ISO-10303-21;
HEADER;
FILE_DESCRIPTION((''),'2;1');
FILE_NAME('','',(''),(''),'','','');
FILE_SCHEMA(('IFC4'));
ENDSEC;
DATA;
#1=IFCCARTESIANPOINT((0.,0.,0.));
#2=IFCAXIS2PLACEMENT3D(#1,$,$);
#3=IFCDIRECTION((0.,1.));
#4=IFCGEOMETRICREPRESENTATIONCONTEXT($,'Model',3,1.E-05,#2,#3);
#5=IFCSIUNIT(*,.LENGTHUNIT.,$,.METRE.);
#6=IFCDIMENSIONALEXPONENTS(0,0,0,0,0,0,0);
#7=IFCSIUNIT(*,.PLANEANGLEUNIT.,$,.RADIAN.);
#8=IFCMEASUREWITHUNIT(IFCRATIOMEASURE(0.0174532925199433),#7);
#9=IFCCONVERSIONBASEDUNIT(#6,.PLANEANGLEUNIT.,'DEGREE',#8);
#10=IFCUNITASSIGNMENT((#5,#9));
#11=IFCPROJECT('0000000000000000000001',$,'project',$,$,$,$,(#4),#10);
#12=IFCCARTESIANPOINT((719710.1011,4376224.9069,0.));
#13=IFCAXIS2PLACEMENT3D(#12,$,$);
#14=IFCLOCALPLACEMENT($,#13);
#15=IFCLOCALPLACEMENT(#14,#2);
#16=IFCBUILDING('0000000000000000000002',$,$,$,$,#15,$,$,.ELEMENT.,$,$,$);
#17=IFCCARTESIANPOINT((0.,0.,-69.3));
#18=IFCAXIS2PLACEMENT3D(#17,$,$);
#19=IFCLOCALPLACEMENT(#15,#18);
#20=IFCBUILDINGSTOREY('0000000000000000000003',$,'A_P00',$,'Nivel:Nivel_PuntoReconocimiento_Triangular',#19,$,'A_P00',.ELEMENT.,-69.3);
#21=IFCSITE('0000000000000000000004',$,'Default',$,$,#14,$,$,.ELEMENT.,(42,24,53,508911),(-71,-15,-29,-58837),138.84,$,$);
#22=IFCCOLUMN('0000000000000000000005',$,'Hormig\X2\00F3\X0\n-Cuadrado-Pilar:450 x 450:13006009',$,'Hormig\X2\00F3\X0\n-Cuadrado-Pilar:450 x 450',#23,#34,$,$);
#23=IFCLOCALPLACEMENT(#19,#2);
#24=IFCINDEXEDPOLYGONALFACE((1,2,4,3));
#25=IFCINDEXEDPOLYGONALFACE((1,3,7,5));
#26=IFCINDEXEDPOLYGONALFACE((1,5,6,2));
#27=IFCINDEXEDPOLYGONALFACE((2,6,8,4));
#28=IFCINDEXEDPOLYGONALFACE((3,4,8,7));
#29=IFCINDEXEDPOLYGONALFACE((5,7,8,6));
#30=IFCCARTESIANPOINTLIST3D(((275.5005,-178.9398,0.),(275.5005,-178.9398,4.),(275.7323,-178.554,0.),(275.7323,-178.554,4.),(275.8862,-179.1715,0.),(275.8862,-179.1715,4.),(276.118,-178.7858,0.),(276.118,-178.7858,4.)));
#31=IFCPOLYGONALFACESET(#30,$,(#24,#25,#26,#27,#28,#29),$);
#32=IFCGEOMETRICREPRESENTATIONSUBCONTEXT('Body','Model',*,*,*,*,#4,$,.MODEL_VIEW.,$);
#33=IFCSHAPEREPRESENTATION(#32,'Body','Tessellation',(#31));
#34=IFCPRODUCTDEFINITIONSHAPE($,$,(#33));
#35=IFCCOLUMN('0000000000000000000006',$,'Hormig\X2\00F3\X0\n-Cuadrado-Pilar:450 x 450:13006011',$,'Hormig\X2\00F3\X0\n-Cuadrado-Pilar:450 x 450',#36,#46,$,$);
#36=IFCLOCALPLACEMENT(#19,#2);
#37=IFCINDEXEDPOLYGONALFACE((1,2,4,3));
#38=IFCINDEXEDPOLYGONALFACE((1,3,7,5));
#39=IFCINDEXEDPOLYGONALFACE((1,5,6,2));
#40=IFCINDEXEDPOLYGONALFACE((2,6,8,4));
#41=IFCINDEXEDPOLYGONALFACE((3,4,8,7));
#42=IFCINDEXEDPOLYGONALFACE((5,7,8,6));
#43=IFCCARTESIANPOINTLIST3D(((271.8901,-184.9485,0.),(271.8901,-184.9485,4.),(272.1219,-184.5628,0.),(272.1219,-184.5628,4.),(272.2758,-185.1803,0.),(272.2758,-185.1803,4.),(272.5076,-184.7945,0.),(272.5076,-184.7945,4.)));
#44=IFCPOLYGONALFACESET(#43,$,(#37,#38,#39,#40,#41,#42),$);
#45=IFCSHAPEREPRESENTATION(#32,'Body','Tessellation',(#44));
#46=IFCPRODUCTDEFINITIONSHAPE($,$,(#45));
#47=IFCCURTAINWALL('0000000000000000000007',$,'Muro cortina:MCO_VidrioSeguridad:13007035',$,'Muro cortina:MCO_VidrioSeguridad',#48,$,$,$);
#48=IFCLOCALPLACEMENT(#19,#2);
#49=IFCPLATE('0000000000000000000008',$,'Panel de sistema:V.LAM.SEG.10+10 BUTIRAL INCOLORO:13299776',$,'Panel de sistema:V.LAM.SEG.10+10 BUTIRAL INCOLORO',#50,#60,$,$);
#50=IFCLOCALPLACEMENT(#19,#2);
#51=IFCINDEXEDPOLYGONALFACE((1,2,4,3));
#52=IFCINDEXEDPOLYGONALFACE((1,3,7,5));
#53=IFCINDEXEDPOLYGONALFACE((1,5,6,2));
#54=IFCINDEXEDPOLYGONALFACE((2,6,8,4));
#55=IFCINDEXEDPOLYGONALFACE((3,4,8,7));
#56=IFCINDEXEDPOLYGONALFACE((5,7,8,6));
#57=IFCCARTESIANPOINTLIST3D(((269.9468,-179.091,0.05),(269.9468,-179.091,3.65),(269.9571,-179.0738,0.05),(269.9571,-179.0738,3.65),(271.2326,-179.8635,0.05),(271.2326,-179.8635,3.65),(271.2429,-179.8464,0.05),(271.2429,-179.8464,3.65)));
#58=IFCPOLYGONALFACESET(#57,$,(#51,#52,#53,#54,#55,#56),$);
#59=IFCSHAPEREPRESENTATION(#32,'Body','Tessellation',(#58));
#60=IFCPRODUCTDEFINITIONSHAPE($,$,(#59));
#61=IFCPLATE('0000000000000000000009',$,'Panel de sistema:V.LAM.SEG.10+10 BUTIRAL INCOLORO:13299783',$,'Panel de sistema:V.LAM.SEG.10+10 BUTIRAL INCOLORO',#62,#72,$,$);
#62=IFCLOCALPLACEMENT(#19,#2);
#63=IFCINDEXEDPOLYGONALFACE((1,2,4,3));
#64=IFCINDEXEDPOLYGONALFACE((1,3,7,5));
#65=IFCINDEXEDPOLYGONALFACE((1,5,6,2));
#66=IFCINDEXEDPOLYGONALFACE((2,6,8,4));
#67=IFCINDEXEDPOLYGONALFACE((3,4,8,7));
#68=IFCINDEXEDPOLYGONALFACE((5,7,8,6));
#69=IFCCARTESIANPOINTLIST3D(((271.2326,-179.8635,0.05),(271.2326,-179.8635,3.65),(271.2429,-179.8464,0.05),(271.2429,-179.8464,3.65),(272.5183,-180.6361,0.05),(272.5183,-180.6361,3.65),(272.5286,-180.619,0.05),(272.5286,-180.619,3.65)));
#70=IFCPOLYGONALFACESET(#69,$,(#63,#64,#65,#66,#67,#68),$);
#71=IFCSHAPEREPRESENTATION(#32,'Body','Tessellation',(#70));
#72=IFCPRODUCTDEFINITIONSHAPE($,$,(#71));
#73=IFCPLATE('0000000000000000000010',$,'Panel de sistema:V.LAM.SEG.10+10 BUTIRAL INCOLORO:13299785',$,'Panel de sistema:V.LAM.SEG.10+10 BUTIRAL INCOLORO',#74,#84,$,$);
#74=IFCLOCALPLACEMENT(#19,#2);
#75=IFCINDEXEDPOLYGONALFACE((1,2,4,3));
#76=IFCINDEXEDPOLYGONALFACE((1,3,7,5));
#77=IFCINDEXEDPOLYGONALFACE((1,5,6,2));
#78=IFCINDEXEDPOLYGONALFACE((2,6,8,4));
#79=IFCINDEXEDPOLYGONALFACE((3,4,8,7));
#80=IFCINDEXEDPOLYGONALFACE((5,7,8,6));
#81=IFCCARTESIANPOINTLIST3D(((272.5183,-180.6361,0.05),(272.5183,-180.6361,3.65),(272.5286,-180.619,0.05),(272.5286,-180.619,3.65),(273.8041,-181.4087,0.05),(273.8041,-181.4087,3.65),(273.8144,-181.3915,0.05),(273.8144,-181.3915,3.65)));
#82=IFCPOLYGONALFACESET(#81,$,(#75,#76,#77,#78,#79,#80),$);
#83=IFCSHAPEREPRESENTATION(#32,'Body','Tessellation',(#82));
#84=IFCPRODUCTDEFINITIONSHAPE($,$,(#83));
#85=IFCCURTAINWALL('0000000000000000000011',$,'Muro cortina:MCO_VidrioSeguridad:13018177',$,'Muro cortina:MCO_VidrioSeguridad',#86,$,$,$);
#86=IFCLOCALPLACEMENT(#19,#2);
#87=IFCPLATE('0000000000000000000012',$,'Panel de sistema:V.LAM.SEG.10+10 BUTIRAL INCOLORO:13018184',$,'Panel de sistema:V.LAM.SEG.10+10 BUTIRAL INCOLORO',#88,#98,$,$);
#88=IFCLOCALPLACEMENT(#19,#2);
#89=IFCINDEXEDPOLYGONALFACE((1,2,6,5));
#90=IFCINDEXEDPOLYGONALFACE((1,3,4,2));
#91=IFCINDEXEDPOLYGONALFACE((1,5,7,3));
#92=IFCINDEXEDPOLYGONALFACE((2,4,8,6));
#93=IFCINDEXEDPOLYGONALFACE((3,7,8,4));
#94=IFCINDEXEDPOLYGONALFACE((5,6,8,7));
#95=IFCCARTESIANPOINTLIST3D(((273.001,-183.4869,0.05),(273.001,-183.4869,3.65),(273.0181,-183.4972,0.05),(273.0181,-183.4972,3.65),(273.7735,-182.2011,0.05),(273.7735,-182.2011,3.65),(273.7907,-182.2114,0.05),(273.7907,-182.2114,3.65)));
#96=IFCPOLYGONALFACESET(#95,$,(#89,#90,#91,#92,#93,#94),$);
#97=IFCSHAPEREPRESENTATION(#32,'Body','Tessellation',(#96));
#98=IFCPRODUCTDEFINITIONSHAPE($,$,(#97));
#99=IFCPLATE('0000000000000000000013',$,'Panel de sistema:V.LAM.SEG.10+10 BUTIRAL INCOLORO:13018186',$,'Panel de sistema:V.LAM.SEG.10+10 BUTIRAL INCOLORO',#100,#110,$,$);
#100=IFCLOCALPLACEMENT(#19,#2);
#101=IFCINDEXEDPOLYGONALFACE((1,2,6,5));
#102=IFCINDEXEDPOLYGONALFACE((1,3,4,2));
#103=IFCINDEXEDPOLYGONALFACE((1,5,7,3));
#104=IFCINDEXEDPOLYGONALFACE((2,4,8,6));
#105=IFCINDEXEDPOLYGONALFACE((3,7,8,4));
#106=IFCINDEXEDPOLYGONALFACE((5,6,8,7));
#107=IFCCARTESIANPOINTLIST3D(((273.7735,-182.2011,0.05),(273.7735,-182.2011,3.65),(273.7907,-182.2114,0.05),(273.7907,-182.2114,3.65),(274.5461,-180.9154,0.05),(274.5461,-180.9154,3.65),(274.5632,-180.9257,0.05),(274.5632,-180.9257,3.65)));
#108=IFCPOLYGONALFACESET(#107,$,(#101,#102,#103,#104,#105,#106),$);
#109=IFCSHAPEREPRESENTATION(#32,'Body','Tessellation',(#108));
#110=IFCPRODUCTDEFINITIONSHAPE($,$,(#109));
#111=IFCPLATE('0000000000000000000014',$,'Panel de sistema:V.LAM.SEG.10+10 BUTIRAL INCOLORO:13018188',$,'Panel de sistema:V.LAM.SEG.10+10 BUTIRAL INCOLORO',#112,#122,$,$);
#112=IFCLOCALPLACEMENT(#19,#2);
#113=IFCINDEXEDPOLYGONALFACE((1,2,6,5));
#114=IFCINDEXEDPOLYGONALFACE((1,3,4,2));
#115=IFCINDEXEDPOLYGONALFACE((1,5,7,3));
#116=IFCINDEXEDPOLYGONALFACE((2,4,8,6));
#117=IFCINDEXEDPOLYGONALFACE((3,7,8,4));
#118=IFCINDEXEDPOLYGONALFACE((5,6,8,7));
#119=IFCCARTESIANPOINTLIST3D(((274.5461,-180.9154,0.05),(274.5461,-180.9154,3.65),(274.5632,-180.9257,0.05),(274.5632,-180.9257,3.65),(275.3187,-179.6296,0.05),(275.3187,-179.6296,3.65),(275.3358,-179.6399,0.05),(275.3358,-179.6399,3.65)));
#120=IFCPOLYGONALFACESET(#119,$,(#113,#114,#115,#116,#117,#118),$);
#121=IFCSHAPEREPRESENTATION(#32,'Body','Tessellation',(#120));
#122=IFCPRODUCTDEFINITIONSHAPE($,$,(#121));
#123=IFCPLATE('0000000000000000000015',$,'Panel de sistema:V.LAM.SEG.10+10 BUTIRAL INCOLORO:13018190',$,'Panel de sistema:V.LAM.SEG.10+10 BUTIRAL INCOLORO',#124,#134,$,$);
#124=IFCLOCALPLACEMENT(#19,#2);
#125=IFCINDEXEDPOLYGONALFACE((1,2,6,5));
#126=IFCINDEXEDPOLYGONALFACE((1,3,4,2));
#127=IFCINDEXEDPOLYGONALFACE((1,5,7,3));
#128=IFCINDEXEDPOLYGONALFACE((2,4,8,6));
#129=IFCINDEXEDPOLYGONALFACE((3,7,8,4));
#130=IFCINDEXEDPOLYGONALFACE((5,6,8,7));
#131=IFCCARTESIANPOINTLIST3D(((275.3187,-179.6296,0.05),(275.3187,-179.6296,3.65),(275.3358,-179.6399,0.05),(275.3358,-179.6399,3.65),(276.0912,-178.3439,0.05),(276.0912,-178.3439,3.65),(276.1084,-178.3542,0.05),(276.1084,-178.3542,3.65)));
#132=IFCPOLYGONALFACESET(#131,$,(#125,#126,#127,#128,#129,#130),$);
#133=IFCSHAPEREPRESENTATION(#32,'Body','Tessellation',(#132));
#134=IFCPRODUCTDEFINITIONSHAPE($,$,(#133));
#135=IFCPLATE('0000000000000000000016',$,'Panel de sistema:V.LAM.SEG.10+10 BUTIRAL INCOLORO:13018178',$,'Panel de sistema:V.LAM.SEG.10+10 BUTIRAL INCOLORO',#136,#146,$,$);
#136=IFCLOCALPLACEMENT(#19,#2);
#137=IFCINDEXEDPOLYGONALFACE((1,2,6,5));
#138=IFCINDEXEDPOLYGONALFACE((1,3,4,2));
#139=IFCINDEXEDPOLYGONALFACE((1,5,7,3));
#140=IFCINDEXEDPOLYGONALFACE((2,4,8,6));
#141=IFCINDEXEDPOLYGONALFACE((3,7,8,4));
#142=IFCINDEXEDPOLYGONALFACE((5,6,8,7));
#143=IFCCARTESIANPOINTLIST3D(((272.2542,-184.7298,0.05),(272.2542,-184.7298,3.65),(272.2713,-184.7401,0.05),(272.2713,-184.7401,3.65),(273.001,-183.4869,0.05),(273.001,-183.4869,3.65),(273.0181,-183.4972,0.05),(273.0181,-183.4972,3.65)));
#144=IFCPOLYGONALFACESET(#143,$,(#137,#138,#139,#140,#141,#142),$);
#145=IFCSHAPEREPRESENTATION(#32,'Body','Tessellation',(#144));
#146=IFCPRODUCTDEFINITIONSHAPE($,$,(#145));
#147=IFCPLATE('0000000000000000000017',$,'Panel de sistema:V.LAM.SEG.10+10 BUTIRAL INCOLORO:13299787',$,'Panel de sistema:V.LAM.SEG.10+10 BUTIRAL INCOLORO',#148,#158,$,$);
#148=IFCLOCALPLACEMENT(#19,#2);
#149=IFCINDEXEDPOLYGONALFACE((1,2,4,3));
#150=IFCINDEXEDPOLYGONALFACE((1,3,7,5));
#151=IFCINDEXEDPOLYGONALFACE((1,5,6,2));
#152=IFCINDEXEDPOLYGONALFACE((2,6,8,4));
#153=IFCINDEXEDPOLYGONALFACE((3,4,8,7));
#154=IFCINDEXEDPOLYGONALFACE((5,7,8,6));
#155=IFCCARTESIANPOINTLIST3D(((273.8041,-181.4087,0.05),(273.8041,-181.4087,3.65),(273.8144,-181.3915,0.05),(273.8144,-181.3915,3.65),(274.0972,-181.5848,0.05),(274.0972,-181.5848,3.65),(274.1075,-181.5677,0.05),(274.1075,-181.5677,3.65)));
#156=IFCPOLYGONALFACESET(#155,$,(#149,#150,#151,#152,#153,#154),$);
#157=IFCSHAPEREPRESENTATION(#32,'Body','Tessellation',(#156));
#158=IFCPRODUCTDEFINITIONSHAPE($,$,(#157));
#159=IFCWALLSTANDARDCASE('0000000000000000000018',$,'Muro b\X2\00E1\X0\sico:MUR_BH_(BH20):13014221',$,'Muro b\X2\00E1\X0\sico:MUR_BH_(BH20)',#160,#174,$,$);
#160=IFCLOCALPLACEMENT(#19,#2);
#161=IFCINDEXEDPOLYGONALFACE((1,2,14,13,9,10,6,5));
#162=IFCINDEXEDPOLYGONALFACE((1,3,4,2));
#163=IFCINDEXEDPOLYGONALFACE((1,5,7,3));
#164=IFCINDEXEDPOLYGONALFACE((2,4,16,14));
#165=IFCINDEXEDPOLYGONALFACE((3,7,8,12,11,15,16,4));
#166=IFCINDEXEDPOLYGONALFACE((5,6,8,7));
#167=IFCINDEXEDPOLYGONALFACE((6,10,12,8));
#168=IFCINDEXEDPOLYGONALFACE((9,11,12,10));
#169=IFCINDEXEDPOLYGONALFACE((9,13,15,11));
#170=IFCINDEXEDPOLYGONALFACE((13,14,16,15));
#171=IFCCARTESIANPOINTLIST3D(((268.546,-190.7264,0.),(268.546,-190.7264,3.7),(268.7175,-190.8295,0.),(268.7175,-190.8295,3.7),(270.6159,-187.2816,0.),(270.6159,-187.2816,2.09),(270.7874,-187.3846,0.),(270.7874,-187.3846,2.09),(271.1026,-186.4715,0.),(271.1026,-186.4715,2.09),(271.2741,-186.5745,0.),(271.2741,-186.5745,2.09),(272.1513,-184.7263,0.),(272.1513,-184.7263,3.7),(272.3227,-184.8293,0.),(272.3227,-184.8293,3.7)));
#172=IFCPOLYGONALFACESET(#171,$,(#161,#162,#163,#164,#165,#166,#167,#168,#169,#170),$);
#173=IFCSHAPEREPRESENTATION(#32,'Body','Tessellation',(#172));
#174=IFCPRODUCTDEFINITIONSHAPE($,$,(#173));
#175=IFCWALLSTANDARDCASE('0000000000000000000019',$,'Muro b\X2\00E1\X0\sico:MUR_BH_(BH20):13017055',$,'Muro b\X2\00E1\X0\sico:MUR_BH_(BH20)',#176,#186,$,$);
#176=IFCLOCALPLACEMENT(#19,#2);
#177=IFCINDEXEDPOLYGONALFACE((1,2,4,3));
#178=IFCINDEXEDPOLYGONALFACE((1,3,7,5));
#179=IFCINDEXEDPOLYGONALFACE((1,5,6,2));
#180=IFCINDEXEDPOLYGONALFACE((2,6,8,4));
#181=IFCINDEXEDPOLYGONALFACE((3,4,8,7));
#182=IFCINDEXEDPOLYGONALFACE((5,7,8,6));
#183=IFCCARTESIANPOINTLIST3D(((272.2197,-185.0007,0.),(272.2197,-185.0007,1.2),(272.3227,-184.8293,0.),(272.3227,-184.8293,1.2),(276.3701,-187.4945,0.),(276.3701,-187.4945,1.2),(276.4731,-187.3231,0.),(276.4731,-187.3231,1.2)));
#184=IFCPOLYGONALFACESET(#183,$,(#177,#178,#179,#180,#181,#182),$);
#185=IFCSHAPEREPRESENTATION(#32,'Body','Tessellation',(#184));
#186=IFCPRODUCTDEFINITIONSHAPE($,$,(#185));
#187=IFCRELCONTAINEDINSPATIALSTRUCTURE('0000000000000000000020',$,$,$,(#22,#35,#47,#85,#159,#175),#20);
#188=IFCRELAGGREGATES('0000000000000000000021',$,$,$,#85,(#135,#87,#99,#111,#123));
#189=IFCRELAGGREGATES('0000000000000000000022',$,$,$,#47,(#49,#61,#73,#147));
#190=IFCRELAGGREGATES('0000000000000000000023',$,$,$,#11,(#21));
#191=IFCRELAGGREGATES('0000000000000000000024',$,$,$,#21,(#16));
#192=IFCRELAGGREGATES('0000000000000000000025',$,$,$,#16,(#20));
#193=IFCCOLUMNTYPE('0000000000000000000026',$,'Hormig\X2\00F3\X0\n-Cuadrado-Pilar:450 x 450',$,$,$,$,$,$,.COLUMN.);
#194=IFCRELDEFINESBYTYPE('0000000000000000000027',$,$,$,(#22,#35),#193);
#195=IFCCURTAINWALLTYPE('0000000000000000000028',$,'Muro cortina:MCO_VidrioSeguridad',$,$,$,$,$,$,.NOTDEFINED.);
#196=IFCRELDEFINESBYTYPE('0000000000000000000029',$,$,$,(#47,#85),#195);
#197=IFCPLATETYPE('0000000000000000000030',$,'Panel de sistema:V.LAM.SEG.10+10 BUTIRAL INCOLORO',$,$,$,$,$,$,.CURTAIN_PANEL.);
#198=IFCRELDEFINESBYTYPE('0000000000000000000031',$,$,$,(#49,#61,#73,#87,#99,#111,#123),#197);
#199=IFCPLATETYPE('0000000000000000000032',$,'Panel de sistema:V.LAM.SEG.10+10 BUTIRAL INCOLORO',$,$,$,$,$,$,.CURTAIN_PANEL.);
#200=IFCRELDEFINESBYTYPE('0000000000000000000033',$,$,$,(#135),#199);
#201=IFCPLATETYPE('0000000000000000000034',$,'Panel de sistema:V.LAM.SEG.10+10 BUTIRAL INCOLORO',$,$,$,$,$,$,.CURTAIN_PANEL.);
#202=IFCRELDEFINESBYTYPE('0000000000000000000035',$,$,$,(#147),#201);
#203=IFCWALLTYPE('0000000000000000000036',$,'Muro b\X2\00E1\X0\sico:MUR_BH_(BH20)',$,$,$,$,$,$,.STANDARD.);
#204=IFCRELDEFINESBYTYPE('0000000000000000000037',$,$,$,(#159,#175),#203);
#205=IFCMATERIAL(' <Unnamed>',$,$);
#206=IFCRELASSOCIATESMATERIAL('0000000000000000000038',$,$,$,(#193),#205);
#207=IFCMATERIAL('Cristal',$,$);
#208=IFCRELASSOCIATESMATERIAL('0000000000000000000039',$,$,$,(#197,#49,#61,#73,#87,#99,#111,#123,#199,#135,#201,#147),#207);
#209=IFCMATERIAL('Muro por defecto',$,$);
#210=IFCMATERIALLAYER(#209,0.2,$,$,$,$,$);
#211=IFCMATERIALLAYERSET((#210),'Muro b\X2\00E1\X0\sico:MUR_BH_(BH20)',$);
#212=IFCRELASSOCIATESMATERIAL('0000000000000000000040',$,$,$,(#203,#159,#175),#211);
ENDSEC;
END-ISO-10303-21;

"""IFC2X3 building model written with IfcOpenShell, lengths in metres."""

from ifc_helpers import new_model, entity, si_unit, converted_unit, direction, frame, frame_2d, origin, origin_2d_with_axis, place, context, subcontext, project, spatial, rectangle, extrude, source, transform, mapped, material, layer, layer_set, layer_usage, type_object, type_shapes, element, aggregate, save


model = new_model("IFC2X3")

# Units and contexts
model_context = context("Model", 3, precision=1e-05, world=origin(), true_north=direction((0.0, 1.0)))
body_context = subcontext(model_context, "Body", "Model", "MODEL_VIEW")
ifc_project = project(units=[si_unit("LENGTHUNIT", "METRE"), converted_unit("PLANEANGLEUNIT", "DEGREE", entity("IfcRatioMeasure", 0.0174532925199433), si_unit("PLANEANGLEUNIT", "RADIAN"), dimensions=[0, 0, 0, 0, 0, 0, 0])], contexts=[model_context])

# Site, building, storey
site_placement = place(None, frame((719710.1011, 4376224.9069, 0.0)))
site = spatial("IfcSite", under=ifc_project, at=site_placement, Name="Default", CompositionType="ELEMENT", RefLatitude=(42, 24, 53, 508911), RefLongitude=(-71, -15, -29, -58837), RefElevation=138.84)
building_placement = place(site_placement, origin())
building = spatial("IfcBuilding", under=site, at=building_placement, CompositionType="ELEMENT")
storey_placement = place(building_placement, frame((0.0, 0.0, -69.3)))
storey = spatial("IfcBuildingStorey", under=building, at=storey_placement, Name="A_P00", ObjectType="Nivel:Nivel_PuntoReconocimiento_Triangular", LongName="A_P00", CompositionType="ELEMENT", Elevation=-69.3)

# Columns
ifc_material_1 = material(Name=" <Unnamed>")
column_type = type_object("IfcColumnType", Name="Hormigón-Cuadrado-Pilar:450 x 450", PredefinedType="COLUMN", material=ifc_material_1)
shared_shape_1 = source(origin(), body_context, "Body", "SweptSolid", [
    extrude(rectangle(XDim=0.45, YDim=0.45, at=origin_2d_with_axis()), frame((0.0, 0.0, -69.3), z_axis=(0.0, 0.0, 1.0), x_axis=(0.0, -1.0, 0.0)), (0.0, 0.0, 1.0), 4.0),
])
type_shapes(column_type, [shared_shape_1])
for number, where, z_axis, x_axis, name in (
    (1, (275.8093, -178.8628, 69.3), (0.0, 0.0, 1.0), (0.857167, -0.515038, 0.0), "Hormigón-Cuadrado-Pilar:450 x 450:13006009"),
    (2, (272.1988, -184.8715, 69.3), (0.0, 0.0, 1.0), (0.857167, -0.515038, 0.0), "Hormigón-Cuadrado-Pilar:450 x 450:13006011"),
):
    element("IfcColumn", number, at=place(storey_placement, frame(where, z_axis=z_axis, x_axis=x_axis)), inside=storey, type_object=column_type, Name=name, ObjectType="Hormigón-Cuadrado-Pilar:450 x 450", context=body_context, shape_type="MappedRepresentation", body=[
        mapped(shared_shape_1, transform((0.0, 0.0, 0.0), scale=1.0)),
    ])

# Curtain walls, plates
curtain_wall_type = type_object("IfcCurtainWallType", Name="Muro cortina:MCO_VidrioSeguridad", PredefinedType="NOTDEFINED")
curtain_wall_1_placement = place(storey_placement, frame((0.0, 0.0, 69.3)))
curtain_wall_1 = element("IfcCurtainWall", 3, at=curtain_wall_1_placement, inside=storey, type_object=curtain_wall_type, Name="Muro cortina:MCO_VidrioSeguridad:13007035", ObjectType="Muro cortina:MCO_VidrioSeguridad")
ifc_material_2 = material(Name="Cristal")
plate_type_1 = type_object("IfcPlateType", Name="Panel de sistema:V.LAM.SEG.10+10 BUTIRAL INCOLORO", PredefinedType="CURTAIN_PANEL", material=ifc_material_2)
shared_shape_2 = source(origin(), body_context, "Body", "SweptSolid", [
    extrude(rectangle(XDim=0.02, YDim=1.5, at=origin_2d_with_axis()), frame((0.0, 0.0, 0.0), z_axis=(0.0, 0.0, 1.0), x_axis=(0.0, 1.0, 0.0)), (0.0, 0.0, 1.0), 3.6),
])
type_shapes(plate_type_1, [shared_shape_2])
plate_1_placement = place(curtain_wall_1_placement, frame((270.5948, -179.4687, -69.25), z_axis=(0.0, 0.0, 1.0), x_axis=(0.857167, -0.515038, 0.0)))
plate_1 = element("IfcPlate", 4, at=plate_1_placement, type_object=plate_type_1, material=ifc_material_2, Name="Panel de sistema:V.LAM.SEG.10+10 BUTIRAL INCOLORO:13299776", ObjectType="Panel de sistema:V.LAM.SEG.10+10 BUTIRAL INCOLORO", context=body_context, shape_type="MappedRepresentation", body=[
    mapped(shared_shape_2, transform((0.0, 0.0, 0.0), scale=1.0)),
])
plate_2_placement = place(curtain_wall_1_placement, frame((271.8806, -180.2412, -69.25), z_axis=(0.0, 0.0, 1.0), x_axis=(0.857167, -0.515038, 0.0)))
plate_2 = element("IfcPlate", 5, at=plate_2_placement, type_object=plate_type_1, material=ifc_material_2, Name="Panel de sistema:V.LAM.SEG.10+10 BUTIRAL INCOLORO:13299783", ObjectType="Panel de sistema:V.LAM.SEG.10+10 BUTIRAL INCOLORO", context=body_context, shape_type="MappedRepresentation", body=[
    mapped(shared_shape_2, transform((0.0, 0.0, 0.0), scale=1.0)),
])
plate_3_placement = place(curtain_wall_1_placement, frame((273.1663, -181.0138, -69.25), z_axis=(0.0, 0.0, 1.0), x_axis=(0.857167, -0.515038, 0.0)))
plate_3 = element("IfcPlate", 6, at=plate_3_placement, type_object=plate_type_1, material=ifc_material_2, Name="Panel de sistema:V.LAM.SEG.10+10 BUTIRAL INCOLORO:13299785", ObjectType="Panel de sistema:V.LAM.SEG.10+10 BUTIRAL INCOLORO", context=body_context, shape_type="MappedRepresentation", body=[
    mapped(shared_shape_2, transform((0.0, 0.0, 0.0), scale=1.0)),
])
curtain_wall_2_placement = place(storey_placement, frame((0.0, 0.0, 69.3)))
curtain_wall_2 = element("IfcCurtainWall", 7, at=curtain_wall_2_placement, inside=storey, type_object=curtain_wall_type, Name="Muro cortina:MCO_VidrioSeguridad:13018177", ObjectType="Muro cortina:MCO_VidrioSeguridad")
plate_4_placement = place(curtain_wall_2_placement, frame((273.3958, -182.8492, -69.25), z_axis=(0.0, 0.0, 1.0), x_axis=(0.515038, 0.857167, 0.0)))
plate_4 = element("IfcPlate", 8, at=plate_4_placement, type_object=plate_type_1, material=ifc_material_2, Name="Panel de sistema:V.LAM.SEG.10+10 BUTIRAL INCOLORO:13018184", ObjectType="Panel de sistema:V.LAM.SEG.10+10 BUTIRAL INCOLORO", context=body_context, shape_type="MappedRepresentation", body=[
    mapped(shared_shape_2, transform((0.0, 0.0, 0.0), scale=1.0)),
])
plate_5_placement = place(curtain_wall_2_placement, frame((274.1684, -181.5634, -69.25), z_axis=(0.0, 0.0, 1.0), x_axis=(0.515038, 0.857167, 0.0)))
plate_5 = element("IfcPlate", 9, at=plate_5_placement, type_object=plate_type_1, material=ifc_material_2, Name="Panel de sistema:V.LAM.SEG.10+10 BUTIRAL INCOLORO:13018186", ObjectType="Panel de sistema:V.LAM.SEG.10+10 BUTIRAL INCOLORO", context=body_context, shape_type="MappedRepresentation", body=[
    mapped(shared_shape_2, transform((0.0, 0.0, 0.0), scale=1.0)),
])
plate_6_placement = place(curtain_wall_2_placement, frame((274.941, -180.2777, -69.25), z_axis=(0.0, 0.0, 1.0), x_axis=(0.515038, 0.857167, 0.0)))
plate_6 = element("IfcPlate", 10, at=plate_6_placement, type_object=plate_type_1, material=ifc_material_2, Name="Panel de sistema:V.LAM.SEG.10+10 BUTIRAL INCOLORO:13018188", ObjectType="Panel de sistema:V.LAM.SEG.10+10 BUTIRAL INCOLORO", context=body_context, shape_type="MappedRepresentation", body=[
    mapped(shared_shape_2, transform((0.0, 0.0, 0.0), scale=1.0)),
])
plate_7_placement = place(curtain_wall_2_placement, frame((275.7135, -178.9919, -69.25), z_axis=(0.0, 0.0, 1.0), x_axis=(0.515038, 0.857167, 0.0)))
plate_7 = element("IfcPlate", 11, at=plate_7_placement, type_object=plate_type_1, material=ifc_material_2, Name="Panel de sistema:V.LAM.SEG.10+10 BUTIRAL INCOLORO:13018190", ObjectType="Panel de sistema:V.LAM.SEG.10+10 BUTIRAL INCOLORO", context=body_context, shape_type="MappedRepresentation", body=[
    mapped(shared_shape_2, transform((0.0, 0.0, 0.0), scale=1.0)),
])
plate_type_2 = type_object("IfcPlateType", Name="Panel de sistema:V.LAM.SEG.10+10 BUTIRAL INCOLORO", PredefinedType="CURTAIN_PANEL", material=ifc_material_2)
shared_shape_3 = source(origin(), body_context, "Body", "SweptSolid", [
    extrude(rectangle(XDim=0.02, YDim=1.45, at=origin_2d_with_axis()), frame((0.0, 0.0, 0.0), z_axis=(0.0, 0.0, 1.0), x_axis=(0.0, 1.0, 0.0)), (0.0, 0.0, 1.0), 3.6),
])
type_shapes(plate_type_2, [shared_shape_3])
plate_8_placement = place(curtain_wall_2_placement, frame((272.6362, -184.1135, -69.25), z_axis=(0.0, 0.0, 1.0), x_axis=(0.515038, 0.857167, 0.0)))
plate_8 = element("IfcPlate", 12, at=plate_8_placement, type_object=plate_type_2, material=ifc_material_2, Name="Panel de sistema:V.LAM.SEG.10+10 BUTIRAL INCOLORO:13018178", ObjectType="Panel de sistema:V.LAM.SEG.10+10 BUTIRAL INCOLORO", context=body_context, shape_type="MappedRepresentation", body=[
    mapped(shared_shape_3, transform((0.0, 0.0, 0.0), scale=1.0)),
])
aggregate(curtain_wall_2, [plate_8, plate_4, plate_5, plate_6, plate_7])

# Plate
plate_type_3 = type_object("IfcPlateType", Name="Panel de sistema:V.LAM.SEG.10+10 BUTIRAL INCOLORO", PredefinedType="CURTAIN_PANEL", material=ifc_material_2)
shared_shape_4 = source(origin(), body_context, "Body", "SweptSolid", [
    extrude(rectangle(XDim=0.02, YDim=0.342, at=origin_2d_with_axis()), frame((0.0, 0.0, 0.0), z_axis=(0.0, 0.0, 1.0), x_axis=(0.0, 1.0, 0.0)), (0.0, 0.0, 1.0), 3.6),
])
type_shapes(plate_type_3, [shared_shape_4])
plate_9_placement = place(curtain_wall_1_placement, frame((273.9558, -181.4882, -69.25), z_axis=(0.0, 0.0, 1.0), x_axis=(0.857167, -0.515038, 0.0)))
plate_9 = element("IfcPlate", 13, at=plate_9_placement, type_object=plate_type_3, material=ifc_material_2, Name="Panel de sistema:V.LAM.SEG.10+10 BUTIRAL INCOLORO:13299787", ObjectType="Panel de sistema:V.LAM.SEG.10+10 BUTIRAL INCOLORO", context=body_context, shape_type="MappedRepresentation", body=[
    mapped(shared_shape_4, transform((0.0, 0.0, 0.0), scale=1.0)),
])
aggregate(curtain_wall_1, [plate_1, plate_2, plate_3, plate_9])

# Wall, opening
ifc_material_3 = material(Name="Muro por defecto")
ifc_layer_1 = layer(ifc_material_3, 0.2)
ifc_layer_set_1 = layer_set([ifc_layer_1], Name="Muro básico:MUR_BH_(BH20)")
ifc_layer_usage_1 = layer_usage(ifc_layer_set_1, "AXIS2", "NEGATIVE", 0.1)
wall_type_1 = type_object("IfcWallType", Name="Muro básico:MUR_BH_(BH20)", PredefinedType="STANDARD", material=ifc_layer_set_1)
wall_1_placement = place(storey_placement, frame((272.237, -184.7778, 0.0), z_axis=(0.0, 0.0, 1.0), x_axis=(-0.515038, -0.857167, 0.0)))
wall_1 = element("IfcWallStandardCase", 14, at=wall_1_placement, inside=storey, type_object=wall_type_1, material=ifc_layer_usage_1, Name="Muro básico:MUR_BH_(BH20):13014221", ObjectType="Muro básico:MUR_BH_(BH20)", context=body_context, shape_type="SweptSolid", body=[
    extrude(rectangle(XDim=7.0, YDim=0.2, at=frame_2d((3.5, 0.0), x_axis=(-1.0, 0.0))), origin(), (0.0, 0.0, 1.0), 3.7),
])
opening_1_placement = place(wall_1_placement, frame((-18.173, -328.5202, 0.0), z_axis=(0.0, 0.0, 1.0), x_axis=(-0.515038, 0.857167, 0.0)))
element("IfcOpeningElement", 15, at=opening_1_placement, cuts=wall_1, ObjectType="Opening", context=body_context, shape_type="SweptSolid", body=[
    extrude(rectangle(XDim=2.09, YDim=0.945, at=frame_2d((0.0, 0.0), x_axis=(1.0, 0.0))), frame((270.8593, -186.8765, 1.045), z_axis=(0.857167, -0.515038, 0.0), x_axis=(0.0, 0.0, -1.0)), (0.0, 0.0, 1.0), 0.2),
])

# Wall
ifc_layer_usage_2 = layer_usage(ifc_layer_set_1, "AXIS2", "NEGATIVE", 0.1)
wall_2_placement = place(storey_placement, frame((272.2712, -184.915, 0.0), z_axis=(0.0, 0.0, 1.0), x_axis=(0.857167, -0.515038, 0.0)))
element("IfcWallStandardCase", 16, at=wall_2_placement, inside=storey, type_object=wall_type_1, material=ifc_layer_usage_2, Name="Muro básico:MUR_BH_(BH20):13017055", ObjectType="Muro básico:MUR_BH_(BH20)", context=body_context, shape_type="SweptSolid", body=[
    extrude(rectangle(XDim=4.842, YDim=0.2, at=frame_2d((2.421, 0.0), x_axis=(-1.0, 0.0))), origin(), (0.0, 0.0, 1.0), 1.2),
])

save(model, "model.ifc")
